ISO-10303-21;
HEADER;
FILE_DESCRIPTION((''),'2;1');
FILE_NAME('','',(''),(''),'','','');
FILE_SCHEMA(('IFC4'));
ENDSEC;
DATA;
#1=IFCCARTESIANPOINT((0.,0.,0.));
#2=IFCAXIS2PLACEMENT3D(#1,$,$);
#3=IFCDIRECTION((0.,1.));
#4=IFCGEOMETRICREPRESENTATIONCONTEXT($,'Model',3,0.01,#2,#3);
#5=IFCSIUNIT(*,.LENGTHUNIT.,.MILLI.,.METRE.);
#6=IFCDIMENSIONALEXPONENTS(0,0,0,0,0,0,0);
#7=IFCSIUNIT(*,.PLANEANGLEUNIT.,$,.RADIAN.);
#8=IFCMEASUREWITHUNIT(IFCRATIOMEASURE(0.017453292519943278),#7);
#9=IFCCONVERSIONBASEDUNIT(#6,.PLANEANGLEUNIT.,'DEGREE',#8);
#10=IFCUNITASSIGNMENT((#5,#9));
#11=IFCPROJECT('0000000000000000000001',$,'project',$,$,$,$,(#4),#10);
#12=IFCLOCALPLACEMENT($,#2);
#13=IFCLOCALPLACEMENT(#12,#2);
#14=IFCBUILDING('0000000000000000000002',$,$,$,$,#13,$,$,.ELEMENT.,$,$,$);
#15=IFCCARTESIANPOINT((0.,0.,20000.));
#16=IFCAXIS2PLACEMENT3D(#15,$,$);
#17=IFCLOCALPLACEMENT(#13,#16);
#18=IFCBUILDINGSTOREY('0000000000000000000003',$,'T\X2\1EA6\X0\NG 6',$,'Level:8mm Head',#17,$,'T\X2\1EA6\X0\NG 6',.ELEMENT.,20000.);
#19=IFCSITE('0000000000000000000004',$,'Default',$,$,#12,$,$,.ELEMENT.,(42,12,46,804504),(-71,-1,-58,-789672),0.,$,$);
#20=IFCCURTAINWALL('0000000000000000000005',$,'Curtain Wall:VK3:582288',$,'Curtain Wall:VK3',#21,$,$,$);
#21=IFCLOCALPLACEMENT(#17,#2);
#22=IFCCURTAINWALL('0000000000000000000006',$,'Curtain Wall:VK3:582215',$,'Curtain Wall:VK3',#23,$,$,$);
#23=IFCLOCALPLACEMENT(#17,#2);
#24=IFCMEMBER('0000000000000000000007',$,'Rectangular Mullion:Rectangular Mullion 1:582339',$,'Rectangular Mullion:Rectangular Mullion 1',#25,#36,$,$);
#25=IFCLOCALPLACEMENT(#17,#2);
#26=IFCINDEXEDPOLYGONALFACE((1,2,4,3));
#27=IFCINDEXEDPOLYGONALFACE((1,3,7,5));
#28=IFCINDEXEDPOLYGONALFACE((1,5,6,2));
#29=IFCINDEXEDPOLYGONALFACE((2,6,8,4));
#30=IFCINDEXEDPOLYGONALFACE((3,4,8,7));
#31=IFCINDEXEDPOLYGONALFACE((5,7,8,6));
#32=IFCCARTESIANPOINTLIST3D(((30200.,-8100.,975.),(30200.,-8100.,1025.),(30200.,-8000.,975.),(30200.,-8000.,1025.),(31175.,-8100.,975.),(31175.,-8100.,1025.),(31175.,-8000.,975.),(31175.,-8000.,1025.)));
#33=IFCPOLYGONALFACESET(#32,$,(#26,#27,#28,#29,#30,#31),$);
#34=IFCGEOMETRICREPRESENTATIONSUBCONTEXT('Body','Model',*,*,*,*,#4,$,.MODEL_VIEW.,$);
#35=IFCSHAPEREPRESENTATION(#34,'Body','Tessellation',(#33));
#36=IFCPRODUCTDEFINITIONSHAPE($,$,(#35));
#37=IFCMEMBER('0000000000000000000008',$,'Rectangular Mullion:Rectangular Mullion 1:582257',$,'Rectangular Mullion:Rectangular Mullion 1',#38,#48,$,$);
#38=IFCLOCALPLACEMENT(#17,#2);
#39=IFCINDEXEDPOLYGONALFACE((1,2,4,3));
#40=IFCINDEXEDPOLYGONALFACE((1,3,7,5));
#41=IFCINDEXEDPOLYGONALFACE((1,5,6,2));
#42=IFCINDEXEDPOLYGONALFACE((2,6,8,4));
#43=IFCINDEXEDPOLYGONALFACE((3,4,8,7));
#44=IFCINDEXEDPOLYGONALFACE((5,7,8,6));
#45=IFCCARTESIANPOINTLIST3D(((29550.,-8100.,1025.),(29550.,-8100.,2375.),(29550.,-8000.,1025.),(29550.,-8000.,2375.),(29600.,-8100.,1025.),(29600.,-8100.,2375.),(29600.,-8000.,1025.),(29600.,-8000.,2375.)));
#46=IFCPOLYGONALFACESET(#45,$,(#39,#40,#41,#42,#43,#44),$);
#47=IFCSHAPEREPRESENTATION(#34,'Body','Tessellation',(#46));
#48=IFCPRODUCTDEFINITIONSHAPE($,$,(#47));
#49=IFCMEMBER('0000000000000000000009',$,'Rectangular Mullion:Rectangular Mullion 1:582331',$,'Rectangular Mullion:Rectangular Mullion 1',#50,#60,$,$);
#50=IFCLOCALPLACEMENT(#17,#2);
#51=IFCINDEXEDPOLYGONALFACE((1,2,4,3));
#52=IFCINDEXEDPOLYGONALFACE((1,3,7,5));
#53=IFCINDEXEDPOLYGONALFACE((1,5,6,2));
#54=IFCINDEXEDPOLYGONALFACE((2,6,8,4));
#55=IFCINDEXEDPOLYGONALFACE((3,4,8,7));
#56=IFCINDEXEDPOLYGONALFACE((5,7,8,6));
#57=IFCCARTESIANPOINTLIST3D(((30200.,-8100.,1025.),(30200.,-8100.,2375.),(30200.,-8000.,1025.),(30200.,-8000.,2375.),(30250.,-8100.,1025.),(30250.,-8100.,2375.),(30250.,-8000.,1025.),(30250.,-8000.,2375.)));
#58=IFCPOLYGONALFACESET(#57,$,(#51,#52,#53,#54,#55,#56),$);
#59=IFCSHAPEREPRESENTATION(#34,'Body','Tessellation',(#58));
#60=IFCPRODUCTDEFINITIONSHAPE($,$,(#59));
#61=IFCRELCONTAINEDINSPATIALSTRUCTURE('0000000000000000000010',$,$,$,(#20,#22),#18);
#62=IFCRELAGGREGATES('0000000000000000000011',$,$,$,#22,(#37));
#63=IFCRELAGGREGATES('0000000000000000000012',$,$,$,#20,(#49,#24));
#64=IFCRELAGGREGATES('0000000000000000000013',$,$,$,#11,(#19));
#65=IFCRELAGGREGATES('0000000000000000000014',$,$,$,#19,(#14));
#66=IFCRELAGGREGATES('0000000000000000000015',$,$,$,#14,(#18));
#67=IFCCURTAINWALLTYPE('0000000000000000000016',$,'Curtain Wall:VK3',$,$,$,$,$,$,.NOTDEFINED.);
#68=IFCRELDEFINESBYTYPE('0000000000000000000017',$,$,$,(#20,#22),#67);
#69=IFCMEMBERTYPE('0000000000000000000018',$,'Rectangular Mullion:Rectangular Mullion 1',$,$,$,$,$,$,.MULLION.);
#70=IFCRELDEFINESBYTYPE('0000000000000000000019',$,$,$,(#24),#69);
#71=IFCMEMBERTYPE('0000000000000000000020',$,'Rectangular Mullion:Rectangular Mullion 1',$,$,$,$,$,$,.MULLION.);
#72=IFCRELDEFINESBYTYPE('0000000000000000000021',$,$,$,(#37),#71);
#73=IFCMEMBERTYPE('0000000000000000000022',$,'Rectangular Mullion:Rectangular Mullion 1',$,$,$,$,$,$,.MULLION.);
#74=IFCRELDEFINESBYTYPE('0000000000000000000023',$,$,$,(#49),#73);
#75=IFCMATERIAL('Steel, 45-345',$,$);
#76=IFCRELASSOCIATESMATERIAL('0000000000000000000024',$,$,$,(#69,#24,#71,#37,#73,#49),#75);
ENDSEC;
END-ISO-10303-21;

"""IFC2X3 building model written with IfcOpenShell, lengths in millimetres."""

from ifc_helpers import new_model, entity, si_unit, converted_unit, direction, frame, origin, origin_2d_with_axis, place, context, subcontext, project, spatial, rectangle, extrude, source, transform, mapped, material, type_object, type_shapes, element, aggregate, save


model = new_model("IFC2X3")

# Units and contexts
model_context = context("Model", 3, precision=0.01, world=origin(), true_north=direction((0.0, 1.0)))
body_context = subcontext(model_context, "Body", "Model", "MODEL_VIEW")
ifc_project = project(units=[si_unit("LENGTHUNIT", "METRE", prefix="MILLI"), converted_unit("PLANEANGLEUNIT", "DEGREE", entity("IfcRatioMeasure", 0.017453292519943278), si_unit("PLANEANGLEUNIT", "RADIAN"), dimensions=[0, 0, 0, 0, 0, 0, 0])], contexts=[model_context])

# Site, building, storey
site_placement = place(None, origin())
site = spatial("IfcSite", under=ifc_project, at=site_placement, Name="Default", CompositionType="ELEMENT", RefLatitude=(42, 12, 46, 804504), RefLongitude=(-71, -1, -58, -789672), RefElevation=0.0)
building_placement = place(site_placement, origin())
building = spatial("IfcBuilding", under=site, at=building_placement, CompositionType="ELEMENT")
storey_placement = place(building_placement, frame((0.0, 0.0, 20000.0)))
storey = spatial("IfcBuildingStorey", under=building, at=storey_placement, Name="TẦNG 6", ObjectType="Level:8mm Head", LongName="TẦNG 6", CompositionType="ELEMENT", Elevation=20000.0)

# Curtain walls
curtain_wall_type = type_object("IfcCurtainWallType", Name="Curtain Wall:VK3", PredefinedType="NOTDEFINED")
curtain_wall_1_placement = place(storey_placement, frame((0.0, 0.0, -20000.0)))
curtain_wall_1 = element("IfcCurtainWall", 1, at=curtain_wall_1_placement, inside=storey, type_object=curtain_wall_type, Name="Curtain Wall:VK3:582288", ObjectType="Curtain Wall:VK3")
ifc_material_1 = material(Name="Steel, 45-345")
curtain_wall_2_placement = place(storey_placement, frame((0.0, 0.0, -20000.0)))
curtain_wall_2 = element("IfcCurtainWall", 2, at=curtain_wall_2_placement, inside=storey, type_object=curtain_wall_type, Name="Curtain Wall:VK3:582215", ObjectType="Curtain Wall:VK3")

# Members
member_type_1 = type_object("IfcMemberType", Name="Rectangular Mullion:Rectangular Mullion 1", PredefinedType="MULLION", material=ifc_material_1)
shared_shape_1 = source(origin(), body_context, "Body", "SweptSolid", [
    extrude(rectangle(XDim=100.0, YDim=50.0, at=origin_2d_with_axis()), frame((0.0, 50.0, -975.0), z_axis=(0.0, 0.0, 1.0), x_axis=(0.0, -1.0, 0.0)), (0.0, 0.0, 1.0), 975.0),
])
type_shapes(member_type_1, [shared_shape_1])
member_1_placement = place(curtain_wall_1_placement, frame((31175.0, -8000.0, 21000.0), z_axis=(1.0, 0.0, 0.0), x_axis=(0.0, 0.0, 1.0)))
member_1 = element("IfcMember", 3, at=member_1_placement, type_object=member_type_1, material=ifc_material_1, Name="Rectangular Mullion:Rectangular Mullion 1:582339", ObjectType="Rectangular Mullion:Rectangular Mullion 1", context=body_context, shape_type="MappedRepresentation", body=[
    mapped(shared_shape_1, transform((0.0, 0.0, 0.0), scale=1.0)),
])
member_type_2 = type_object("IfcMemberType", Name="Rectangular Mullion:Rectangular Mullion 1", PredefinedType="MULLION", material=ifc_material_1)
shared_shape_2 = source(origin(), body_context, "Body", "SweptSolid", [
    extrude(rectangle(XDim=100.0, YDim=50.0, at=origin_2d_with_axis()), frame((-25.0, 50.0, -1350.0), z_axis=(0.0, 0.0, 1.0), x_axis=(0.0, -1.0, 0.0)), (0.0, 0.0, 1.0), 1350.0),
])
type_shapes(member_type_2, [shared_shape_2])
member_2_placement = place(curtain_wall_2_placement, frame((29600.0, -8000.0, 21025.0), z_axis=(0.0, 0.0, -1.0), x_axis=(1.0, 0.0, 0.0)))
member_2 = element("IfcMember", 4, at=member_2_placement, type_object=member_type_2, material=ifc_material_1, Name="Rectangular Mullion:Rectangular Mullion 1:582257", ObjectType="Rectangular Mullion:Rectangular Mullion 1", context=body_context, shape_type="MappedRepresentation", body=[
    mapped(shared_shape_2, transform((0.0, 0.0, 0.0), scale=1.0)),
])
member_type_3 = type_object("IfcMemberType", Name="Rectangular Mullion:Rectangular Mullion 1", PredefinedType="MULLION", material=ifc_material_1)
shared_shape_3 = source(origin(), body_context, "Body", "SweptSolid", [
    extrude(rectangle(XDim=100.0, YDim=50.0, at=origin_2d_with_axis()), frame((-25.0, 50.0, -1350.0), z_axis=(0.0, 0.0, 1.0), x_axis=(0.0, -1.0, 0.0)), (0.0, 0.0, 1.0), 1350.0),
])
type_shapes(member_type_3, [shared_shape_3])
member_3_placement = place(curtain_wall_1_placement, frame((30200.0, -8000.0, 22375.0), z_axis=(0.0, 0.0, 1.0), x_axis=(-1.0, 0.0, 0.0)))
member_3 = element("IfcMember", 5, at=member_3_placement, type_object=member_type_3, material=ifc_material_1, Name="Rectangular Mullion:Rectangular Mullion 1:582331", ObjectType="Rectangular Mullion:Rectangular Mullion 1", context=body_context, shape_type="MappedRepresentation", body=[
    mapped(shared_shape_3, transform((0.0, 0.0, 0.0), scale=1.0)),
])

aggregate(curtain_wall_2, [member_2])
aggregate(curtain_wall_1, [member_3, member_1])

save(model, "model.ifc")
